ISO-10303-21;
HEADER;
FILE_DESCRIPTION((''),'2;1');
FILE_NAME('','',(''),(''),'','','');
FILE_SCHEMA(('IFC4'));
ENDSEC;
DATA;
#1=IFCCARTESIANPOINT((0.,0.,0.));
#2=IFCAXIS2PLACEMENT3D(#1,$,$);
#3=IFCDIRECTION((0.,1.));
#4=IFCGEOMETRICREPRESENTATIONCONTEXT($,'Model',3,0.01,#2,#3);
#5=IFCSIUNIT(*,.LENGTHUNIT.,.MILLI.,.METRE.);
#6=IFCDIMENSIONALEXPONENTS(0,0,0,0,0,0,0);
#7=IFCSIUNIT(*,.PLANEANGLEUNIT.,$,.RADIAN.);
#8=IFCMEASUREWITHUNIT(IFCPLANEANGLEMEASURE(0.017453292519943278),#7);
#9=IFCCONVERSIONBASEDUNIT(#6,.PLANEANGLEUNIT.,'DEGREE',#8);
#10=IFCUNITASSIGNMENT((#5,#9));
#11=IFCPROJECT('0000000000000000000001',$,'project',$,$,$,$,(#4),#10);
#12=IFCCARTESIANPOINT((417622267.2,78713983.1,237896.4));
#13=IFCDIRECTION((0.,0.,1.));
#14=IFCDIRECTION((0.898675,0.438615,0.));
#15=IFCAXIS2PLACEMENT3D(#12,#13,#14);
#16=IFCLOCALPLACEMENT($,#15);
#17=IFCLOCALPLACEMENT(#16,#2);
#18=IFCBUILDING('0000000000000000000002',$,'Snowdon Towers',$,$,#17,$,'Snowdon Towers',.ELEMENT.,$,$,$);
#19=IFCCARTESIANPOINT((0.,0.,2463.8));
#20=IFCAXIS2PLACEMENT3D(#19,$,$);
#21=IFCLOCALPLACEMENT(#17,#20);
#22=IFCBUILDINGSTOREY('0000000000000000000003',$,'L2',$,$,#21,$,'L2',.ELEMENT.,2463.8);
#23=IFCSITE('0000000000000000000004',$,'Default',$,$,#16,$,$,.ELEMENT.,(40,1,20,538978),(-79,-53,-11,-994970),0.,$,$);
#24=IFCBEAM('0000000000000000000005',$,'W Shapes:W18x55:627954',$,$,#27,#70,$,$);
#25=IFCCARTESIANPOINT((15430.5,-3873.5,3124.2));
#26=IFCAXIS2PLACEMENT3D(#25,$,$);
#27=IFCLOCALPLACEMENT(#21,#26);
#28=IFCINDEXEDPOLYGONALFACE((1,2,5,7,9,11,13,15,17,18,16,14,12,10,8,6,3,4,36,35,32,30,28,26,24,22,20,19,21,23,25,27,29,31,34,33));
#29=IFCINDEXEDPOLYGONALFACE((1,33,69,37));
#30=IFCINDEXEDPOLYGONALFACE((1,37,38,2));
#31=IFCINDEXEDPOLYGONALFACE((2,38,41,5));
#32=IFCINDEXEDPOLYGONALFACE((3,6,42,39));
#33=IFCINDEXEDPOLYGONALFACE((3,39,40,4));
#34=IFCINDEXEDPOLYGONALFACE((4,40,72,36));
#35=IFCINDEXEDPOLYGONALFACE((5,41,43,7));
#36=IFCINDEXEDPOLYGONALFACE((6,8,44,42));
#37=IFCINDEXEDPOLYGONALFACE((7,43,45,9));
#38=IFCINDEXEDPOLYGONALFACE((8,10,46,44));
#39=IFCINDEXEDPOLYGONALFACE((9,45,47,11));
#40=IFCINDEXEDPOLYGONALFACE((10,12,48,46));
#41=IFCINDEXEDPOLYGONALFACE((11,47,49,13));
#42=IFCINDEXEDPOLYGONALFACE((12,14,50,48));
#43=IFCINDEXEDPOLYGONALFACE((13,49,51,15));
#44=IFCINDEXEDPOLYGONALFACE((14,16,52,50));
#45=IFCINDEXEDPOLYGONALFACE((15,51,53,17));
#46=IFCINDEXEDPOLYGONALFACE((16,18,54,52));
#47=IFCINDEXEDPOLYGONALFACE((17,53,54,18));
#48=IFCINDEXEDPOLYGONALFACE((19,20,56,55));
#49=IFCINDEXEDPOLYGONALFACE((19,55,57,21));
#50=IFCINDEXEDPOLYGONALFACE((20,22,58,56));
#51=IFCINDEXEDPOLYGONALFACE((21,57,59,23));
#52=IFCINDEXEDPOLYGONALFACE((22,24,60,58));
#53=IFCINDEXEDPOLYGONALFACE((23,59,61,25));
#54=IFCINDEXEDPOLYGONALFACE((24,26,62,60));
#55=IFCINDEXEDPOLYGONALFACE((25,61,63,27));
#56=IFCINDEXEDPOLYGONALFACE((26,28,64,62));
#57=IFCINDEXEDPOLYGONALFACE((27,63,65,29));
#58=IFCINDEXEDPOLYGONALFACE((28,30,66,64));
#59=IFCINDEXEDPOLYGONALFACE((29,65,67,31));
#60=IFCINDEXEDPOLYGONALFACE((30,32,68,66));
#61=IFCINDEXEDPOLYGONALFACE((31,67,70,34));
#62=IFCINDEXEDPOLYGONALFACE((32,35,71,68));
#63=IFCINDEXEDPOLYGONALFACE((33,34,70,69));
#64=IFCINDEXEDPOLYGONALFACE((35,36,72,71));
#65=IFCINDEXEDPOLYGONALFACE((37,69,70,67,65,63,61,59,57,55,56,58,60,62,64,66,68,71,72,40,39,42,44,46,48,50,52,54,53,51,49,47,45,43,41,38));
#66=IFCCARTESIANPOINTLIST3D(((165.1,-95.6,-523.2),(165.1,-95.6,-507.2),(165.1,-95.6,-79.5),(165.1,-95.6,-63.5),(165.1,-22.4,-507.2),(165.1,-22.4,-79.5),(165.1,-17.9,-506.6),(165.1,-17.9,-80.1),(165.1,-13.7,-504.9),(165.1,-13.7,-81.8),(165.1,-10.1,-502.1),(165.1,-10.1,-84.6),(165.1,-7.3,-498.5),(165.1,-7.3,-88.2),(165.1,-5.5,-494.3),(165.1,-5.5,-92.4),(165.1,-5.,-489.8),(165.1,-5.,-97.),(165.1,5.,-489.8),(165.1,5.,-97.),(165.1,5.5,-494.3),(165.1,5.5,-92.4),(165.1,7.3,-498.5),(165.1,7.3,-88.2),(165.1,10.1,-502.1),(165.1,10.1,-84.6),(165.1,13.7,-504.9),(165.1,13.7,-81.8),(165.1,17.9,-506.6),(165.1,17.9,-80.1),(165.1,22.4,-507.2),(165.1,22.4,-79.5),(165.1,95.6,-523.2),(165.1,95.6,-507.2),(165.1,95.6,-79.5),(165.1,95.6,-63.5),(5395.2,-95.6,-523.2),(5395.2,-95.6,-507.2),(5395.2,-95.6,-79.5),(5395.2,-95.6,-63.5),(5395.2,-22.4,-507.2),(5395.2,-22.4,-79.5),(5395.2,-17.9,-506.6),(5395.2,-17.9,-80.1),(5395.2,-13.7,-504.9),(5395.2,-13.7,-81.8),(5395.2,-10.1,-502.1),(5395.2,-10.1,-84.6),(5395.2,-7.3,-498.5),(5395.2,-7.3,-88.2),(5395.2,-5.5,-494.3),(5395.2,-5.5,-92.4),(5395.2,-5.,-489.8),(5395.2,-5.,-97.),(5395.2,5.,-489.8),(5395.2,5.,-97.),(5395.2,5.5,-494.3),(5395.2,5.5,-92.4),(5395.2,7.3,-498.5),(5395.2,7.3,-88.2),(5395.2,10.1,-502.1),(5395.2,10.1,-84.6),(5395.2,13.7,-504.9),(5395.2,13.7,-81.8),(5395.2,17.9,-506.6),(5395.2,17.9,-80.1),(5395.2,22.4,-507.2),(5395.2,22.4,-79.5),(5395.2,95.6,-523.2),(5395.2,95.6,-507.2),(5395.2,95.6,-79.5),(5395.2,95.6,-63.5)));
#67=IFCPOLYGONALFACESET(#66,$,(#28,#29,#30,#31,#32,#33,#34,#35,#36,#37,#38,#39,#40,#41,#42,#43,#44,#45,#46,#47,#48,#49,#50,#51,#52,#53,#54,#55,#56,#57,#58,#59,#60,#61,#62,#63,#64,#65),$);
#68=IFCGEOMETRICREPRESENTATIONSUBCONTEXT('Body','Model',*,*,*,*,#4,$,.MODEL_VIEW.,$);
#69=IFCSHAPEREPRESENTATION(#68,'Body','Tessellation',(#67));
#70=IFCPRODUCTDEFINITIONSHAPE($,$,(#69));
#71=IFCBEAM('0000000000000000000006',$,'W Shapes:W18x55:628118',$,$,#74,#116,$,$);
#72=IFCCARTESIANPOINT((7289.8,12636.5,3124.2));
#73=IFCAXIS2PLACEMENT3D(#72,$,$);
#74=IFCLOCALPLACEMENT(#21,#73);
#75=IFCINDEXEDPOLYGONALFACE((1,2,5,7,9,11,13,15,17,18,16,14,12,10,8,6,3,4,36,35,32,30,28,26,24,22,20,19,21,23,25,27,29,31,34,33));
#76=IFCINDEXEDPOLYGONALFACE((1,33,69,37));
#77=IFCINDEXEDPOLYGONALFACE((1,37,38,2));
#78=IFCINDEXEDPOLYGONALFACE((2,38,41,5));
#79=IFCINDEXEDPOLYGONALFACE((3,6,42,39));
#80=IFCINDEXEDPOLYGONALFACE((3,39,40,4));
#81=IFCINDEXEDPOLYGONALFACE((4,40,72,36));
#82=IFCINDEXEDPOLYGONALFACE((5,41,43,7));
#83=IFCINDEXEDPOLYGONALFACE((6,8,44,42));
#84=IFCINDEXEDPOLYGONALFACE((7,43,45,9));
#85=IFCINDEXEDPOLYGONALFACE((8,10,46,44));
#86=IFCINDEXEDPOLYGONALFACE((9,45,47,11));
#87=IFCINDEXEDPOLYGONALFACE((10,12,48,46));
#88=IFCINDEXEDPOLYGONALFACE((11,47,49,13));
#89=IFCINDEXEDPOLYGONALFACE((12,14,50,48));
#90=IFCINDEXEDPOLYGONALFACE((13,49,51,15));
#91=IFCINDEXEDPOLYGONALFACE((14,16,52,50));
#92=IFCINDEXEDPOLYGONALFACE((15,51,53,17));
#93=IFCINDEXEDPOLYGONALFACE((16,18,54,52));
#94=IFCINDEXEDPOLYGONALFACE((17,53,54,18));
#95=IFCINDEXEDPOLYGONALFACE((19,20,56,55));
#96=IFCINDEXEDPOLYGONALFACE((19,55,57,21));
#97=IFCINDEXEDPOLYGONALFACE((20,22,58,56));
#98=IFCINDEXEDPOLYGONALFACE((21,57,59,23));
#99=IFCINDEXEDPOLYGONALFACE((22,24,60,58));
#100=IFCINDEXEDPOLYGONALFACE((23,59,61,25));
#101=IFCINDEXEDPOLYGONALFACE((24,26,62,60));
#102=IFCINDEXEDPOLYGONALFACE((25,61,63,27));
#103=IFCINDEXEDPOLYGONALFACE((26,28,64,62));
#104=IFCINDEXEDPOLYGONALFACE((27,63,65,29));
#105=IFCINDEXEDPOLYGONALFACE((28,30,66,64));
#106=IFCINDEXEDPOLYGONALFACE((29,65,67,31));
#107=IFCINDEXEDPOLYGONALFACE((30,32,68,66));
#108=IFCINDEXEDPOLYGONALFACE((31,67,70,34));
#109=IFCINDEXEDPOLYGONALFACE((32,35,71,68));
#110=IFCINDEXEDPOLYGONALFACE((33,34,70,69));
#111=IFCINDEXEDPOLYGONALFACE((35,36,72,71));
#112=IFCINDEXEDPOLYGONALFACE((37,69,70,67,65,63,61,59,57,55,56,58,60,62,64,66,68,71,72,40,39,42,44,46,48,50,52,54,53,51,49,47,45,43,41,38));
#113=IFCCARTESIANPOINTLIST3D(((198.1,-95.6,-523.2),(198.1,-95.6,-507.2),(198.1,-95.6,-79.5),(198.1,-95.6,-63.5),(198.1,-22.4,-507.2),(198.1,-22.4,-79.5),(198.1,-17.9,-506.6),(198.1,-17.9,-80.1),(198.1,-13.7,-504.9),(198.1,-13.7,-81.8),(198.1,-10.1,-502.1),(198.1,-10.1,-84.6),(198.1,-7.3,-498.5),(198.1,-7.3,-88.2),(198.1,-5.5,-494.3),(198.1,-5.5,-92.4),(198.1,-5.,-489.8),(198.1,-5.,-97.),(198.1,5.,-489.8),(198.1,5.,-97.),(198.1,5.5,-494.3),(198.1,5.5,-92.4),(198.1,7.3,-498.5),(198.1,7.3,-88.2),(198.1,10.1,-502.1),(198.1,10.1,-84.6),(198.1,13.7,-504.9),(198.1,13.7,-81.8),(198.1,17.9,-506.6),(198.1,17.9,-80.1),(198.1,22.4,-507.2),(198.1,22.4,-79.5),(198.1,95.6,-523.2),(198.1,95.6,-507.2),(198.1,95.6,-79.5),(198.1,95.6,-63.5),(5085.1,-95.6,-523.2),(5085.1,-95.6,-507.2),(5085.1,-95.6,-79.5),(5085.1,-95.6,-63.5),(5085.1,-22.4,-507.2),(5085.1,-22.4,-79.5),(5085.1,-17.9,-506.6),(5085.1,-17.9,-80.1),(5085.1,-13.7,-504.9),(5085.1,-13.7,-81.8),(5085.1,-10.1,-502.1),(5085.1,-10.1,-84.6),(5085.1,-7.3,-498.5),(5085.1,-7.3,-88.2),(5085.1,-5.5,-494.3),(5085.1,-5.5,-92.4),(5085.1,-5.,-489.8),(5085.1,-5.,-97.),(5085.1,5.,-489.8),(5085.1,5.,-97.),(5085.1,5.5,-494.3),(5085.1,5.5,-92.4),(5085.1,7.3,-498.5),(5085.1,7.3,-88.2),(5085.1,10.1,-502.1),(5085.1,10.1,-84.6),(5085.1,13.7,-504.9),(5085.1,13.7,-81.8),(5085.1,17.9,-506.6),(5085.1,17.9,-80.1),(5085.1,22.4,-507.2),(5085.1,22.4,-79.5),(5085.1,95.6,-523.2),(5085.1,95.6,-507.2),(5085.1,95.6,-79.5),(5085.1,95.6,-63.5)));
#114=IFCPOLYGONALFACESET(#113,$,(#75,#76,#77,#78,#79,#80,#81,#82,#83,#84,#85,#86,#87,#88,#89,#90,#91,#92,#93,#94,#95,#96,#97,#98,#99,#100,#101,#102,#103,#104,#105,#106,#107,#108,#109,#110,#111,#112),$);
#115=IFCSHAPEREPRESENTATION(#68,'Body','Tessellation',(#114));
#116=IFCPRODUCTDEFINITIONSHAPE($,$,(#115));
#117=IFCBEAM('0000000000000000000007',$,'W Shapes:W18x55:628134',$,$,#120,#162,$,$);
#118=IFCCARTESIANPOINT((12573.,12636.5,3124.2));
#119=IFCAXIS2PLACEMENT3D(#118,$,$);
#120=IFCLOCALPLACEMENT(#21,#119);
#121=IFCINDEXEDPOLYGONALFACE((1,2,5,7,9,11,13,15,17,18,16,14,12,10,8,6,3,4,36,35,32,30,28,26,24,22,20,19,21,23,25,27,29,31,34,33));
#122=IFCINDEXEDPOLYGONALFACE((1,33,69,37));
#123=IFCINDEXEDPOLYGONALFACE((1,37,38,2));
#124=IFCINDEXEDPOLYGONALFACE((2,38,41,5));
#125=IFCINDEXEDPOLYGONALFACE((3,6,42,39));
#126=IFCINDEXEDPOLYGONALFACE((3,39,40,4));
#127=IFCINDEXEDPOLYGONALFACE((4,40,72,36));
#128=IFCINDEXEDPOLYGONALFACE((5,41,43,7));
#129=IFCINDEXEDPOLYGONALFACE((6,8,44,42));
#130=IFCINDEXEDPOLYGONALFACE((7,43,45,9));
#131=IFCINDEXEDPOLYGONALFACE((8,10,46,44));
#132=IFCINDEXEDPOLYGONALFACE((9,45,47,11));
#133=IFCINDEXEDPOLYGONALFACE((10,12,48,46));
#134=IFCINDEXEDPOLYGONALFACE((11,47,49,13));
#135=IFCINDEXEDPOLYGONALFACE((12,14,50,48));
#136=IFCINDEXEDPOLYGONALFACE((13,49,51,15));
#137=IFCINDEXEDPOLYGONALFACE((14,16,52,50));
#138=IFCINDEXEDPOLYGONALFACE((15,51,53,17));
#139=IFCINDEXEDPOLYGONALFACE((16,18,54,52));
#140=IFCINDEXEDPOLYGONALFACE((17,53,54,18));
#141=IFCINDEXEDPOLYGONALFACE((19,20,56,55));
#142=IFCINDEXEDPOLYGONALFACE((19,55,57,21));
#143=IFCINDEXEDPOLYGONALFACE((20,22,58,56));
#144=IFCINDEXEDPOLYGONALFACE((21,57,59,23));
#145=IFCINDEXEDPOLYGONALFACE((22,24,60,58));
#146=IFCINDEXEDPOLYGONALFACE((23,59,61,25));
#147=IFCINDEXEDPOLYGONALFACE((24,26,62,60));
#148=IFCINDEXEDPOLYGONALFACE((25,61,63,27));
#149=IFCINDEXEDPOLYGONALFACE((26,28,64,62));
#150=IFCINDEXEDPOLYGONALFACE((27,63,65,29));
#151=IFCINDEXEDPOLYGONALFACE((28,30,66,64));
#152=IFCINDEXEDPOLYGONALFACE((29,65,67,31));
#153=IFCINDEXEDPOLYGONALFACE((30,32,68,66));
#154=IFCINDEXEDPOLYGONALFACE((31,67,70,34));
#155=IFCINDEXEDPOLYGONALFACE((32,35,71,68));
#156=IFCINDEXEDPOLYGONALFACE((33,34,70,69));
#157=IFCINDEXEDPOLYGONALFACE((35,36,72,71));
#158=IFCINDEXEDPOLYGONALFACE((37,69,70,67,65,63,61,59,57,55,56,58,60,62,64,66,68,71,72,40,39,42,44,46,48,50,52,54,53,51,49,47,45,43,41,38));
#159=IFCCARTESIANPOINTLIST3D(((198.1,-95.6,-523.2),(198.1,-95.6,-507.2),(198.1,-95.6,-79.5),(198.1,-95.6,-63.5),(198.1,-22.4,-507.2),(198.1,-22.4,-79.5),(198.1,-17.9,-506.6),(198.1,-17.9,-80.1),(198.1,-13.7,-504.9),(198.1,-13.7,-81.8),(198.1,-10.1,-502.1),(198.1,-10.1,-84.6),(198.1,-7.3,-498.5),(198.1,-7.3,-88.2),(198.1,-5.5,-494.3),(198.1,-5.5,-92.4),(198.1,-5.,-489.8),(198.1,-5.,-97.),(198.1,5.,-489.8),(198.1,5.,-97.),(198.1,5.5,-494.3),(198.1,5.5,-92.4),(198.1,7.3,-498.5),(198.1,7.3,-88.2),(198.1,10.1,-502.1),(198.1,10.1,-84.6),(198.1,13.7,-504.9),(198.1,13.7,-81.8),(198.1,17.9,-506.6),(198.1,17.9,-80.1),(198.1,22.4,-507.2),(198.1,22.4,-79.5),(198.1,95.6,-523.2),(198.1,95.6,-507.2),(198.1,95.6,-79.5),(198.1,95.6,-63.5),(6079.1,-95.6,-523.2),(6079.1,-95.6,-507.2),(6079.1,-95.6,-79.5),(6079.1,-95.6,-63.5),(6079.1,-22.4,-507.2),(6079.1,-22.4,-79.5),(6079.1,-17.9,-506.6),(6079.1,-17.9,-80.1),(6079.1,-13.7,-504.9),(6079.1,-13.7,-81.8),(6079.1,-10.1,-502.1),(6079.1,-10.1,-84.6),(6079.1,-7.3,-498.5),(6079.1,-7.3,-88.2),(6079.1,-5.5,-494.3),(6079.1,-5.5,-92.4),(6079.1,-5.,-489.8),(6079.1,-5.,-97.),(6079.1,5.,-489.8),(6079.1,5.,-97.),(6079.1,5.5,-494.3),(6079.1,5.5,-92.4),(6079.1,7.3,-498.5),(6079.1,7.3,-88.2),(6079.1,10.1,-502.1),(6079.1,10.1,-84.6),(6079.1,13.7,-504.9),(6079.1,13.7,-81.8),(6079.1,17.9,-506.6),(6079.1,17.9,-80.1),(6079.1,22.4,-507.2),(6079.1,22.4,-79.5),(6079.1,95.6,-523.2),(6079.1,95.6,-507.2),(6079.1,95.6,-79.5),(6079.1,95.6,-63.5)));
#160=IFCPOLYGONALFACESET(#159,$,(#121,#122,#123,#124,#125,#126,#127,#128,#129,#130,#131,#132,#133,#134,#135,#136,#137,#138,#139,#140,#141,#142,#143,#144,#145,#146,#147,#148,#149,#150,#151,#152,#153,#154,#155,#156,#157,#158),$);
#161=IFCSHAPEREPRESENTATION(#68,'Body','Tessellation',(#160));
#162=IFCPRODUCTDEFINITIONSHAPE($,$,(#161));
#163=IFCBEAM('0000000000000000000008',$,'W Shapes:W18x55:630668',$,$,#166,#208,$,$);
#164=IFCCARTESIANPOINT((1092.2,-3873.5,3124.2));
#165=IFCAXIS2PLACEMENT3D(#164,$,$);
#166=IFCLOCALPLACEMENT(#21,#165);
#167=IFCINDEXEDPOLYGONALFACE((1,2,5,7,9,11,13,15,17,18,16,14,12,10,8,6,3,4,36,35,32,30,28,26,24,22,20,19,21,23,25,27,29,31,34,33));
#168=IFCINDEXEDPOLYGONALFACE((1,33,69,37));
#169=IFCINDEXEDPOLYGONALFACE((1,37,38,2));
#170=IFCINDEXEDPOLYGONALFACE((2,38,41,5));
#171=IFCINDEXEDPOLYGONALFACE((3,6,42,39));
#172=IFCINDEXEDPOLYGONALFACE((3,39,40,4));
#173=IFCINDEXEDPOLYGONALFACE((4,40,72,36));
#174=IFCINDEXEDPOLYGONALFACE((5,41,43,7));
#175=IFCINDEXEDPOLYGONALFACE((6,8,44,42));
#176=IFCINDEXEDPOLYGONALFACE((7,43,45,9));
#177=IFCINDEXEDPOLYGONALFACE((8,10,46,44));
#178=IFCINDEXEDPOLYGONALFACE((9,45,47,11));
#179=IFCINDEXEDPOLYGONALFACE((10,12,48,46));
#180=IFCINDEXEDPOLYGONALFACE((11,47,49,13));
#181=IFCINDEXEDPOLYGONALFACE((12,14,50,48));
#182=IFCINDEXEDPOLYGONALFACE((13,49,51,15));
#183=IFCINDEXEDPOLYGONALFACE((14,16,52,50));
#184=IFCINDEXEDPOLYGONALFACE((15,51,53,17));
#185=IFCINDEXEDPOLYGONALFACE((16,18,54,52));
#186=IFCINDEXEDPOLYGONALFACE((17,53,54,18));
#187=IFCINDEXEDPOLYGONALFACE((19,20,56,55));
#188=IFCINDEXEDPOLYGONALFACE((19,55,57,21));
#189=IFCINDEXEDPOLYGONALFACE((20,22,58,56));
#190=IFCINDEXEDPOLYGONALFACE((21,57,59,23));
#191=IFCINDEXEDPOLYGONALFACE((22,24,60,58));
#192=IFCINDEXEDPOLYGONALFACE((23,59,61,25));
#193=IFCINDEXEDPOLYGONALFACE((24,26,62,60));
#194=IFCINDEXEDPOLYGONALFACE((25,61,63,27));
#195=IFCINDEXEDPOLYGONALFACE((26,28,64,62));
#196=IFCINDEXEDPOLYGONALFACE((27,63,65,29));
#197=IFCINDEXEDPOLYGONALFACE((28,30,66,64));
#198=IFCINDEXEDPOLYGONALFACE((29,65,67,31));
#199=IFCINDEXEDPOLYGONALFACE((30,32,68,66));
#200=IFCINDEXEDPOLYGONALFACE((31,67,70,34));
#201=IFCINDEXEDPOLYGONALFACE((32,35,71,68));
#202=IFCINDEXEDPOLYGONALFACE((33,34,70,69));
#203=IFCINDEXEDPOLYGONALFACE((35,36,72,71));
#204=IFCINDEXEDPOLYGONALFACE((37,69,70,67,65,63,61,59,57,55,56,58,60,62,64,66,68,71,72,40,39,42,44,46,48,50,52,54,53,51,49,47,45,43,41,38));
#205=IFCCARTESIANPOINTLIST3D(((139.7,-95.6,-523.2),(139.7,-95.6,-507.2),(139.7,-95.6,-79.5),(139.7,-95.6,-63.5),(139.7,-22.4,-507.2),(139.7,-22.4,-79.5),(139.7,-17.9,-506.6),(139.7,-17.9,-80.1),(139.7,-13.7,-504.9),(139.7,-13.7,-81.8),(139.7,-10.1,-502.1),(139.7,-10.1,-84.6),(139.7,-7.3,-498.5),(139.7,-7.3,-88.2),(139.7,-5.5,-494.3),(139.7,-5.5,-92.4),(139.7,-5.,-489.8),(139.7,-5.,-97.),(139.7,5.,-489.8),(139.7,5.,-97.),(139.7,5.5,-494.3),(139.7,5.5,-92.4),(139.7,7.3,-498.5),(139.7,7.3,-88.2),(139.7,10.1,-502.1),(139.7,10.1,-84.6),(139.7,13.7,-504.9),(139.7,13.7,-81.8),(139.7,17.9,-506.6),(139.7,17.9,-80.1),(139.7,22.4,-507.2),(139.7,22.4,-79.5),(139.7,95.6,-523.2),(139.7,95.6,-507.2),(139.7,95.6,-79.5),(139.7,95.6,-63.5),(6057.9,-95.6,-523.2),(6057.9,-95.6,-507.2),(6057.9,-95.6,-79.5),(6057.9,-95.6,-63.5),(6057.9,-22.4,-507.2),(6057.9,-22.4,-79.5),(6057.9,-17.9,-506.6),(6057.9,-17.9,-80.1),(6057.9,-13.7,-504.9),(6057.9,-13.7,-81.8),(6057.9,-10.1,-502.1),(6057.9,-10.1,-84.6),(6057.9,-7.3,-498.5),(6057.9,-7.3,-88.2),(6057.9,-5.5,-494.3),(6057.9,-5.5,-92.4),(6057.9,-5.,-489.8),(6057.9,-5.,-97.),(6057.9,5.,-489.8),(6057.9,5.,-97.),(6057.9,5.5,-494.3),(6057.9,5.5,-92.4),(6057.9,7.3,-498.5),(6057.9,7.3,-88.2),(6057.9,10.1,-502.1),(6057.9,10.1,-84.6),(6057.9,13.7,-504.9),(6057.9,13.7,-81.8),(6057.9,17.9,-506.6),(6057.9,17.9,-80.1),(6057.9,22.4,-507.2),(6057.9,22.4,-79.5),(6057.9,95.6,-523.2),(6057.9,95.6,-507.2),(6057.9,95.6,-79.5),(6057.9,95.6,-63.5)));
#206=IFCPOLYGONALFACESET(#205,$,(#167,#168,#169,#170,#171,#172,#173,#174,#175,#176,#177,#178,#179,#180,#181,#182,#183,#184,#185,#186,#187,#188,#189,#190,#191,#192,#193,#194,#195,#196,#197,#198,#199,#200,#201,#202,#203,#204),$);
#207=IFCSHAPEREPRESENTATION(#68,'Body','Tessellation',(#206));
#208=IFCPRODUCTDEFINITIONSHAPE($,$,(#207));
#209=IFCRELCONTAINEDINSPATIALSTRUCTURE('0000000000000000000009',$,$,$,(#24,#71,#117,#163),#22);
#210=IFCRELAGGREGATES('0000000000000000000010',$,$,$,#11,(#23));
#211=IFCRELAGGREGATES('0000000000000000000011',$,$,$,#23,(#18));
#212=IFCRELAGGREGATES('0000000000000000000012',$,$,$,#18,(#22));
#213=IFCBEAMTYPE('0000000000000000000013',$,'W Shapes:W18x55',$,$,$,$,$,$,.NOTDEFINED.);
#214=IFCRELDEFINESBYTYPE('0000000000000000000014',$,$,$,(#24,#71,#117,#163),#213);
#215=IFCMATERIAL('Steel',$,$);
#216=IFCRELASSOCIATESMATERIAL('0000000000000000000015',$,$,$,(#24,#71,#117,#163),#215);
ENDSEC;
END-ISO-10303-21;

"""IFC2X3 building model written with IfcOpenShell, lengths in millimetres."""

from ifc_helpers import new_model, entity, si_unit, converted_unit, direction, frame, frame_2d, origin, place, context, subcontext, project, spatial, i_section, extrude, material, type_object, element, save


model = new_model("IFC2X3")

# Units and contexts
model_context = context("Model", 3, precision=0.01, world=origin(), true_north=direction((0.0, 1.0)))
body_context = subcontext(model_context, "Body", "Model", "MODEL_VIEW")
ifc_project = project(units=[si_unit("LENGTHUNIT", "METRE", prefix="MILLI"), converted_unit("PLANEANGLEUNIT", "DEGREE", entity("IfcPlaneAngleMeasure", 0.017453292519943278), si_unit("PLANEANGLEUNIT", "RADIAN"), dimensions=[0, 0, 0, 0, 0, 0, 0])], contexts=[model_context])

# Site, building, storey
site_placement = place(None, frame((417622267.2, 78713983.1, 237896.4), z_axis=(0.0, 0.0, 1.0), x_axis=(0.898675, 0.438615, 0.0)))
site = spatial("IfcSite", under=ifc_project, at=site_placement, Name="Default", CompositionType="ELEMENT", RefLatitude=(40, 1, 20, 538978), RefLongitude=(-79, -53, -11, -994970), RefElevation=0.0)
building_placement = place(site_placement, origin())
building = spatial("IfcBuilding", under=site, at=building_placement, Name="Snowdon Towers", LongName="Snowdon Towers", CompositionType="ELEMENT")
storey_placement = place(building_placement, frame((0.0, 0.0, 2463.8)))
storey = spatial("IfcBuildingStorey", under=building, at=storey_placement, Name="L2", LongName="L2", CompositionType="ELEMENT", Elevation=2463.8)

# Shared definitions
ifc_material_1 = material(Name="Steel")

# Beams
beam_type_1 = type_object("IfcBeamType", Name="W Shapes:W18x55", PredefinedType="NOTDEFINED")
beam_1_placement = place(storey_placement, frame((15430.5, -3873.5, 3124.2)))
element("IfcBeam", 1, at=beam_1_placement, inside=storey, type_object=beam_type_1, material=ifc_material_1, Name="W Shapes:W18x55:627954", context=body_context, shape_type="SweptSolid", body=[
    extrude(i_section(OverallWidth=191.3, OverallDepth=459.7, WebThickness=9.9, FlangeThickness=16.0, FilletRadius=17.5, at=frame_2d((0.0, 0.0), x_axis=(0.0, 1.0))), frame((165.1, 0.0, -293.4), z_axis=(1.0, 0.0, 0.0), x_axis=(0.0, 0.0, -1.0)), (0.0, 0.0, 1.0), 5230.1),
])
beam_2_placement = place(storey_placement, frame((7289.8, 12636.5, 3124.2)))
element("IfcBeam", 2, at=beam_2_placement, inside=storey, type_object=beam_type_1, material=ifc_material_1, Name="W Shapes:W18x55:628118", context=body_context, shape_type="SweptSolid", body=[
    extrude(i_section(OverallWidth=191.3, OverallDepth=459.7, WebThickness=9.9, FlangeThickness=16.0, FilletRadius=17.5, at=frame_2d((0.0, 0.0), x_axis=(0.0, 1.0))), frame((198.1, 0.0, -293.4), z_axis=(1.0, 0.0, 0.0), x_axis=(0.0, 0.0, -1.0)), (0.0, 0.0, 1.0), 4887.0),
])
beam_3_placement = place(storey_placement, frame((12573.0, 12636.5, 3124.2)))
element("IfcBeam", 3, at=beam_3_placement, inside=storey, type_object=beam_type_1, material=ifc_material_1, Name="W Shapes:W18x55:628134", context=body_context, shape_type="SweptSolid", body=[
    extrude(i_section(OverallWidth=191.3, OverallDepth=459.7, WebThickness=9.9, FlangeThickness=16.0, FilletRadius=17.5, at=frame_2d((0.0, 0.0), x_axis=(0.0, 1.0))), frame((198.1, 0.0, -293.4), z_axis=(1.0, 0.0, 0.0), x_axis=(0.0, 0.0, -1.0)), (0.0, 0.0, 1.0), 5881.0),
])
beam_4_placement = place(storey_placement, frame((1092.2, -3873.5, 3124.2)))
element("IfcBeam", 4, at=beam_4_placement, inside=storey, type_object=beam_type_1, material=ifc_material_1, Name="W Shapes:W18x55:630668", context=body_context, shape_type="SweptSolid", body=[
    extrude(i_section(OverallWidth=191.3, OverallDepth=459.7, WebThickness=9.9, FlangeThickness=16.0, FilletRadius=17.5, at=frame_2d((0.0, 0.0), x_axis=(0.0, 1.0))), frame((139.7, 0.0, -293.4), z_axis=(1.0, 0.0, 0.0), x_axis=(0.0, 0.0, -1.0)), (0.0, 0.0, 1.0), 5918.2),
])

save(model, "model.ifc")
